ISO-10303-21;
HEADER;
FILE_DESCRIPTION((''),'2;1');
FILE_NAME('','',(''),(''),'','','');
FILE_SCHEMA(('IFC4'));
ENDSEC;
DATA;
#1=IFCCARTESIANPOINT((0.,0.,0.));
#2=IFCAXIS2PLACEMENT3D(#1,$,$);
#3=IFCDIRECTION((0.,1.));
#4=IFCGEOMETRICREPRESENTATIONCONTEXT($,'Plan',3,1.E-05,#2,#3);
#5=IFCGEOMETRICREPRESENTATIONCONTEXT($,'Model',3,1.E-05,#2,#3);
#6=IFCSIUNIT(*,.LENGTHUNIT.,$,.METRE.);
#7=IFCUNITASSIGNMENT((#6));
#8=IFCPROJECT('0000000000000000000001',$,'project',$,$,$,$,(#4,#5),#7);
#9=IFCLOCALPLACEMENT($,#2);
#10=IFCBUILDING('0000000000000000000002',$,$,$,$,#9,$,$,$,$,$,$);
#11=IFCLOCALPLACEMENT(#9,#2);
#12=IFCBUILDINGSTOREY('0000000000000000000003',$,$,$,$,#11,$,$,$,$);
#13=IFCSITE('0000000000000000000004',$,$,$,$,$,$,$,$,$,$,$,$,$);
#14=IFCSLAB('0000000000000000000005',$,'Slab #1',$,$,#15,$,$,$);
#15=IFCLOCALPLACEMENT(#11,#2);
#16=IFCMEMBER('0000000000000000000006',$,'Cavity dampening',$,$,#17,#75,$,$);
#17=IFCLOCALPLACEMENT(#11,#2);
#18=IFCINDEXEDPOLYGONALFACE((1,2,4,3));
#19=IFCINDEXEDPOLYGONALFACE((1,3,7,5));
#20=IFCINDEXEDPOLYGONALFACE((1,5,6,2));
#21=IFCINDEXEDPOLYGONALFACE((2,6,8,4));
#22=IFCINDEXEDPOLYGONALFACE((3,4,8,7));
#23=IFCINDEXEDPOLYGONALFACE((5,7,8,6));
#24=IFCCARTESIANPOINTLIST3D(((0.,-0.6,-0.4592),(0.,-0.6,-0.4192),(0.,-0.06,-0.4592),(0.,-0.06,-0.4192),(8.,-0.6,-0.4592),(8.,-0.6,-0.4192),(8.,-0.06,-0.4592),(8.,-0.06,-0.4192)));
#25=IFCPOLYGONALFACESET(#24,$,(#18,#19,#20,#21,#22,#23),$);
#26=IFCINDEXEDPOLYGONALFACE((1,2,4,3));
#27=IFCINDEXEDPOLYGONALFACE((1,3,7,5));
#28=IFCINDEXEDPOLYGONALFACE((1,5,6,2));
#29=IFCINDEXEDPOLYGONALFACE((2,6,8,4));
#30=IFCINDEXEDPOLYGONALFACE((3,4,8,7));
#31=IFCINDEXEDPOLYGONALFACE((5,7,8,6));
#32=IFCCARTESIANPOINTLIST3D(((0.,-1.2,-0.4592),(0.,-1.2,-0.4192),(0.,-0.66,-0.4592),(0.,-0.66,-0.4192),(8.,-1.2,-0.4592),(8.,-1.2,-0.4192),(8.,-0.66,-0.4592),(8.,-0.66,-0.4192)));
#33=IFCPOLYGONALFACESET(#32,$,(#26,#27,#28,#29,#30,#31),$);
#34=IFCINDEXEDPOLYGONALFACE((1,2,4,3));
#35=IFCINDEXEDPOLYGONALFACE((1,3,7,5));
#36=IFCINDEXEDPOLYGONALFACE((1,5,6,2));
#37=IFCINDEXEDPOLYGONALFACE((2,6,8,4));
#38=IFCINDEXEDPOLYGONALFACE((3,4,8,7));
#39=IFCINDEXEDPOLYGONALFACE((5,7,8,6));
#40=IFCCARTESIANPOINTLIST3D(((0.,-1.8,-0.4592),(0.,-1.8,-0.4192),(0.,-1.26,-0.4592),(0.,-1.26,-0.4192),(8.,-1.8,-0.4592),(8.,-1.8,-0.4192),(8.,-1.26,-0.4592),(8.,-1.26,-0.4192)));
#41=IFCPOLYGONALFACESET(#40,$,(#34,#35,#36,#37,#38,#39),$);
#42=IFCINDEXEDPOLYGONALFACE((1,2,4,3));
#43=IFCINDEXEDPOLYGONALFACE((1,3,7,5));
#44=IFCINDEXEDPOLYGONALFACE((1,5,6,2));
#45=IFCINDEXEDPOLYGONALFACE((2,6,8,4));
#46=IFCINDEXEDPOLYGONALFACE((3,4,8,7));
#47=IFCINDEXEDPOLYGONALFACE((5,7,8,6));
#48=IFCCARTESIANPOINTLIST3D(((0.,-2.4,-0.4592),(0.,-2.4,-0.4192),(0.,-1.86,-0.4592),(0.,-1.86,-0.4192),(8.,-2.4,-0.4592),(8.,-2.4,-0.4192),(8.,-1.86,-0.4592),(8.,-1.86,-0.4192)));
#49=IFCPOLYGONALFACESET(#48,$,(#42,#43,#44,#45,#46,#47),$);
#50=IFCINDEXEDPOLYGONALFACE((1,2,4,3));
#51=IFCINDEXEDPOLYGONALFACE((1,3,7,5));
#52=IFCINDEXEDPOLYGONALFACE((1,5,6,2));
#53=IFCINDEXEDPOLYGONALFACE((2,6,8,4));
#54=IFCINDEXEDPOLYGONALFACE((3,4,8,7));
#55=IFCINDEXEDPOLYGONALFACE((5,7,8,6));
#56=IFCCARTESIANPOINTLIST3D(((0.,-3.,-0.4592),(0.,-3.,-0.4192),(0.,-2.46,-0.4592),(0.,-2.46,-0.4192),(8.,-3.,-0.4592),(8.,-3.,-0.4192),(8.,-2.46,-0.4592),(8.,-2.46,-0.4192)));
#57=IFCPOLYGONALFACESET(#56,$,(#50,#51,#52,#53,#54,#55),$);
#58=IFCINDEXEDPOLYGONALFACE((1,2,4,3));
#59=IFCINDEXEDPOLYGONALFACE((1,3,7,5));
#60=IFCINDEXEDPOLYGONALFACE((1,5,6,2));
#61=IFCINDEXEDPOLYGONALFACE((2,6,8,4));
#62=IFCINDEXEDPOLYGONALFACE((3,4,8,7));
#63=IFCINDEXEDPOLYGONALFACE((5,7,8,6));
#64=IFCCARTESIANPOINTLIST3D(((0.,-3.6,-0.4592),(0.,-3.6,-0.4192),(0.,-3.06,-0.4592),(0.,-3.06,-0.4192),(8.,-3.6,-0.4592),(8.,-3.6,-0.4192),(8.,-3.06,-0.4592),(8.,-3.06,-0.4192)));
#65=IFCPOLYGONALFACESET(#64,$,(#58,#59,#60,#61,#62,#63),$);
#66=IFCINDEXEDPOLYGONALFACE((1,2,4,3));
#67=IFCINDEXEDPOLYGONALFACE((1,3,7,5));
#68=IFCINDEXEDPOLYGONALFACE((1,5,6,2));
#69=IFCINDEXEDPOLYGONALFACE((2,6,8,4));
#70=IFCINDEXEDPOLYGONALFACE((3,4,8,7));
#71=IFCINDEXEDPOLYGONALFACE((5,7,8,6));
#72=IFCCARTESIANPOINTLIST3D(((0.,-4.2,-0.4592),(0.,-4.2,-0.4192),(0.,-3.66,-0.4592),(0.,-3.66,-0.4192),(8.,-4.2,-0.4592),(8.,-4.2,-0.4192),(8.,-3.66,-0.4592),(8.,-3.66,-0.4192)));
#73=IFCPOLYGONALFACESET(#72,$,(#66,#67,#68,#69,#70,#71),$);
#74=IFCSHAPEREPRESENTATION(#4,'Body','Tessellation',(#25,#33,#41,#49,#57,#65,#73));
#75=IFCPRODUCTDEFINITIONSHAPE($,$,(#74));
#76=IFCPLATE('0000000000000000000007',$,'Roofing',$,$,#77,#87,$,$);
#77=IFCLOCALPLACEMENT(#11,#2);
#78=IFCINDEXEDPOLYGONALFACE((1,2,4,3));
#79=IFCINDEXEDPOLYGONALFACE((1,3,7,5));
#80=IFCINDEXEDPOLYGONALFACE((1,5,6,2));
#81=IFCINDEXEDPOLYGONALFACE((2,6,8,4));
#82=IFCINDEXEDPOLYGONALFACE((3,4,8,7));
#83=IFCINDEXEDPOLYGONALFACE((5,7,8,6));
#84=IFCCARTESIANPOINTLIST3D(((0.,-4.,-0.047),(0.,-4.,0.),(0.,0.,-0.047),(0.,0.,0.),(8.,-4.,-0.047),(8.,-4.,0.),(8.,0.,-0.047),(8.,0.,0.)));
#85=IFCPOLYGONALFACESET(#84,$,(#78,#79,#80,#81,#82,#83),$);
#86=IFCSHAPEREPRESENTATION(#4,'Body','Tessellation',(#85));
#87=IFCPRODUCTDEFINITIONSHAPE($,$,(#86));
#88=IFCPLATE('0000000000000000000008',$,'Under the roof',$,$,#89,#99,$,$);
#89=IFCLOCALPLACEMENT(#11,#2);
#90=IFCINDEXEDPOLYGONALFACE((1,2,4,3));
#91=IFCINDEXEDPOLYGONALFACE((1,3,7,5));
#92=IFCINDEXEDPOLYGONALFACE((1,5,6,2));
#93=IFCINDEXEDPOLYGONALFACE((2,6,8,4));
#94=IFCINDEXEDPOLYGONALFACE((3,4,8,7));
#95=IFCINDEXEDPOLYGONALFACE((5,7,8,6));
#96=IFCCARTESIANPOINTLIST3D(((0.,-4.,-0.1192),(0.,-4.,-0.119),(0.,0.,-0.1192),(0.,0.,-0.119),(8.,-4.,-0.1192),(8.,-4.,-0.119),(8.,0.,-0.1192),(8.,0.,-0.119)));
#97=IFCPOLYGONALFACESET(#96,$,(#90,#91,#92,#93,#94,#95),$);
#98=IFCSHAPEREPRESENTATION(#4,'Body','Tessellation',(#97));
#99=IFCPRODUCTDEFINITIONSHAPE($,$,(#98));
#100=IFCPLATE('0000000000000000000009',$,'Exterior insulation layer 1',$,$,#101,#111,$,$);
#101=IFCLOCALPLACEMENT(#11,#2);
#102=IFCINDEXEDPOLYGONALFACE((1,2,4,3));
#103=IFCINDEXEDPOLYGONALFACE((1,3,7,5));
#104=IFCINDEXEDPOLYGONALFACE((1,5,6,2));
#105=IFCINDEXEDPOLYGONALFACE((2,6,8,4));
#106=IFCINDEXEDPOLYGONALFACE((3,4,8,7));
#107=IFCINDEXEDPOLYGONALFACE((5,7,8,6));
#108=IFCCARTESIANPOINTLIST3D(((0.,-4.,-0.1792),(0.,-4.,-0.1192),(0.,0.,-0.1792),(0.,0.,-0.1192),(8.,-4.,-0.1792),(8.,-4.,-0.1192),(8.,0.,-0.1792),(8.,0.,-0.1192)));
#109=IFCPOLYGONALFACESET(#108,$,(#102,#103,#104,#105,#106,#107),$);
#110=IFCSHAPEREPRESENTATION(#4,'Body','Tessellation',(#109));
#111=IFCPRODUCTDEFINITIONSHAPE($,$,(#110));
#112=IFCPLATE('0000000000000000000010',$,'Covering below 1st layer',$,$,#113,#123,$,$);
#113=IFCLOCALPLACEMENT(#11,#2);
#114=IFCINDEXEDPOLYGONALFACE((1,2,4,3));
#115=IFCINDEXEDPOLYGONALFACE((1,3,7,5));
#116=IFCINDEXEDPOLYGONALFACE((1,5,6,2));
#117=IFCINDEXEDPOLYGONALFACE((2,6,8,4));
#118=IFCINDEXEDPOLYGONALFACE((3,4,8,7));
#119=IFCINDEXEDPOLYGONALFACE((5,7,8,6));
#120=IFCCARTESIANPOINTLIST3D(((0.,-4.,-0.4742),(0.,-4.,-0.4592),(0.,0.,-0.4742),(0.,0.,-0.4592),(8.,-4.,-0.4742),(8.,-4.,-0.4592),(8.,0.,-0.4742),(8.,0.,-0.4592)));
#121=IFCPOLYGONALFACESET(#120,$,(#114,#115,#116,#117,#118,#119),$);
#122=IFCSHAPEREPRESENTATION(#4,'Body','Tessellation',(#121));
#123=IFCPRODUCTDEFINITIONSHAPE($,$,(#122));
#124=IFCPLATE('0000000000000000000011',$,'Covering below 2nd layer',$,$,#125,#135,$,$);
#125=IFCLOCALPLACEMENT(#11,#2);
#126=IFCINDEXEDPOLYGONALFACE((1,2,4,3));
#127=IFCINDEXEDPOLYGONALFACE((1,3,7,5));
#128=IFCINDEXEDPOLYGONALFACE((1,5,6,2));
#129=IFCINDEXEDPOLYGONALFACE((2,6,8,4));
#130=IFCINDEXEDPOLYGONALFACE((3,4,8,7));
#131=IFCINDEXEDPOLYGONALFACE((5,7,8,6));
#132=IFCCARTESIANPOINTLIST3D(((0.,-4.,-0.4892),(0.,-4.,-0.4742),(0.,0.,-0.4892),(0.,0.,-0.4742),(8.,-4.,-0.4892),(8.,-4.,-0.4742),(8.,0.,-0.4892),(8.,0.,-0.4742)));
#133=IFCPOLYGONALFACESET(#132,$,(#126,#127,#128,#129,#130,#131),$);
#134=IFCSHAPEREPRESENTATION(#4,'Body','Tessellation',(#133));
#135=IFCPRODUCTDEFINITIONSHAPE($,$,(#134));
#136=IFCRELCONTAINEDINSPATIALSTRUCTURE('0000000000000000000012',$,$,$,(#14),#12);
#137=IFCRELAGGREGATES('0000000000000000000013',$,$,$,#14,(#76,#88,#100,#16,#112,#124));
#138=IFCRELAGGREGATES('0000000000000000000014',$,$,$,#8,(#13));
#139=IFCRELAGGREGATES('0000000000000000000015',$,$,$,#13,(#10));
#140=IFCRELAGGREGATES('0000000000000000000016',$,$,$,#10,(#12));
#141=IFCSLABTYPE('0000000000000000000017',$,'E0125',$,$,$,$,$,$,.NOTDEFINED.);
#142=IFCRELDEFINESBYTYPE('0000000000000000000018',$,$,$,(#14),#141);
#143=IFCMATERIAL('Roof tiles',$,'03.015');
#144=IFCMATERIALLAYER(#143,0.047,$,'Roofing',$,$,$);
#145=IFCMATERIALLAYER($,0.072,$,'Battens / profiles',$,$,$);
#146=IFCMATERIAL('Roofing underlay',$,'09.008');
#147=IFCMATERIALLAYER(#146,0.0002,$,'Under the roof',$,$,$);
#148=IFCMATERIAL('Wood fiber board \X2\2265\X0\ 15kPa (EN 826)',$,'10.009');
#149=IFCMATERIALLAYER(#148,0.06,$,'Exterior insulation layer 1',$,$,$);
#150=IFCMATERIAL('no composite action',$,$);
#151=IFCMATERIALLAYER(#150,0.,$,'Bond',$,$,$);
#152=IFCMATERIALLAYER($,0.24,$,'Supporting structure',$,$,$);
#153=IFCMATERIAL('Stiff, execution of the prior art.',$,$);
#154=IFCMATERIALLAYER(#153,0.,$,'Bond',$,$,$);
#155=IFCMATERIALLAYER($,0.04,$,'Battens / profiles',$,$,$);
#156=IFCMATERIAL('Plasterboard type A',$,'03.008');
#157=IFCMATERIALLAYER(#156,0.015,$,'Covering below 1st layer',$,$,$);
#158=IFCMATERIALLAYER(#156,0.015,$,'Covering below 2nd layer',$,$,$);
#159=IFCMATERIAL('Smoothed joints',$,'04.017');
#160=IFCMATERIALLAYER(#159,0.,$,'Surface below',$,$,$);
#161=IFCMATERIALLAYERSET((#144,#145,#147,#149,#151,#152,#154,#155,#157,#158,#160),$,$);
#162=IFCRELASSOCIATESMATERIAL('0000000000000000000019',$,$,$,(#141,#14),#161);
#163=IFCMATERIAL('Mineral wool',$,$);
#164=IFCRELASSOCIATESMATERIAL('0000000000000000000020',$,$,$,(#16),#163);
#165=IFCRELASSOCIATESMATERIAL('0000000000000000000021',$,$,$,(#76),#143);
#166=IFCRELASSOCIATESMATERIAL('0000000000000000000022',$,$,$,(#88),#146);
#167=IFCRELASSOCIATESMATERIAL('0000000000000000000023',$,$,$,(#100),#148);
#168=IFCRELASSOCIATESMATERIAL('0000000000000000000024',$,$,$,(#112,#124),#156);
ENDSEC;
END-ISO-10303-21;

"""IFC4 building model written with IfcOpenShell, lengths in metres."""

from ifc_helpers import new_model, si_unit, direction, frame, frame_2d, origin, origin_with_axes, place, context, project, spatial, rectangle, extrude, material, layer, layer_set, type_object, element, aggregate, save


model = new_model("IFC4")

# Units and contexts
plan_context = context("Plan", 3, precision=1e-05, world=origin(), true_north=direction((0.0, 1.0)))
model_context = context("Model", 3, precision=1e-05, world=origin(), true_north=direction((0.0, 1.0)))
ifc_project = project(units=[si_unit("LENGTHUNIT", "METRE")], contexts=[plan_context, model_context])

# Site, building, storey
site = spatial("IfcSite", under=ifc_project)
building_placement = place(None, origin())
building = spatial("IfcBuilding", under=site, at=building_placement)
storey_placement = place(building_placement, origin())
storey = spatial("IfcBuildingStorey", under=building, at=storey_placement)

# Slab, member, plates
ifc_material_1 = material(Name="Roof tiles", Category="03.015")
ifc_layer_1 = layer(ifc_material_1, 0.047, Name="Roofing")
ifc_layer_2 = layer(None, 0.072, Name="Battens / profiles")
ifc_material_2 = material(Name="Roofing underlay", Category="09.008")
ifc_layer_3 = layer(ifc_material_2, 0.0002, Name="Under the roof")
ifc_material_3 = material(Name="Wood fiber board ≥ 15kPa (EN 826)", Category="10.009")
ifc_layer_4 = layer(ifc_material_3, 0.06, Name="Exterior insulation layer 1")
ifc_material_4 = material(Name="no composite action")
ifc_layer_5 = layer(ifc_material_4, 0.0, Name="Bond")
ifc_layer_6 = layer(None, 0.24, Name="Supporting structure")
ifc_material_5 = material(Name="Stiff, execution of the prior art.")
ifc_layer_7 = layer(ifc_material_5, 0.0, Name="Bond")
ifc_layer_8 = layer(None, 0.04, Name="Battens / profiles")
ifc_material_6 = material(Name="Plasterboard type A", Category="03.008")
ifc_layer_9 = layer(ifc_material_6, 0.015, Name="Covering below 1st layer")
ifc_layer_10 = layer(ifc_material_6, 0.015, Name="Covering below 2nd layer")
ifc_material_7 = material(Name="Smoothed joints", Category="04.017")
ifc_layer_11 = layer(ifc_material_7, 0.0, Name="Surface below")
ifc_layer_set = layer_set([ifc_layer_1, ifc_layer_2, ifc_layer_3, ifc_layer_4, ifc_layer_5, ifc_layer_6, ifc_layer_7, ifc_layer_8, ifc_layer_9, ifc_layer_10, ifc_layer_11])
slab_type = type_object("IfcSlabType", Name="E0125", PredefinedType="NOTDEFINED", material=ifc_layer_set)
slab_placement = place(None, frame((0.0, 0.0, 0.0), z_axis=(0.0, 0.0, -1.0), x_axis=(1.0, 0.0, 0.0)))
slab = element("IfcSlab", 1, at=slab_placement, inside=storey, type_object=slab_type, material=ifc_layer_set, Name="Slab #1")
ifc_material_8 = material(Name="Mineral wool")
member_1_placement = place(slab_placement, origin())
member_1 = element("IfcMember", 2, at=member_1_placement, material=ifc_material_8, Name="Cavity dampening", context=plan_context, shape_type="SweptSolid", body=[
    extrude(rectangle(XDim=0.54, YDim=0.04, at=frame_2d((0.27, 0.02), x_axis=(1.0, 0.0))), frame((0.0, 0.06, 0.4192), z_axis=(1.0, 0.0, 0.0), x_axis=(0.0, 1.0, 0.0)), (0.0, 0.0, 1.0), 8.0),
    extrude(rectangle(XDim=0.54, YDim=0.04, at=frame_2d((0.27, 0.02), x_axis=(1.0, 0.0))), frame((0.0, 0.66, 0.4192), z_axis=(1.0, 0.0, 0.0), x_axis=(0.0, 1.0, 0.0)), (0.0, 0.0, 1.0), 8.0),
    extrude(rectangle(XDim=0.54, YDim=0.04, at=frame_2d((0.27, 0.02), x_axis=(1.0, 0.0))), frame((0.0, 1.26, 0.4192), z_axis=(1.0, 0.0, 0.0), x_axis=(0.0, 1.0, 0.0)), (0.0, 0.0, 1.0), 8.0),
    extrude(rectangle(XDim=0.54, YDim=0.04, at=frame_2d((0.27, 0.02), x_axis=(1.0, 0.0))), frame((0.0, 1.86, 0.4192), z_axis=(1.0, 0.0, 0.0), x_axis=(0.0, 1.0, 0.0)), (0.0, 0.0, 1.0), 8.0),
    extrude(rectangle(XDim=0.54, YDim=0.04, at=frame_2d((0.27, 0.02), x_axis=(1.0, 0.0))), frame((0.0, 2.46, 0.4192), z_axis=(1.0, 0.0, 0.0), x_axis=(0.0, 1.0, 0.0)), (0.0, 0.0, 1.0), 8.0),
    extrude(rectangle(XDim=0.54, YDim=0.04, at=frame_2d((0.27, 0.02), x_axis=(1.0, 0.0))), frame((0.0, 3.06, 0.4192), z_axis=(1.0, 0.0, 0.0), x_axis=(0.0, 1.0, 0.0)), (0.0, 0.0, 1.0), 8.0),
    extrude(rectangle(XDim=0.54, YDim=0.04, at=frame_2d((0.27, 0.02), x_axis=(1.0, 0.0))), frame((0.0, 3.66, 0.4192), z_axis=(1.0, 0.0, 0.0), x_axis=(0.0, 1.0, 0.0)), (0.0, 0.0, 1.0), 8.0),
])
plate_1_placement = place(slab_placement, origin())
plate_1 = element("IfcPlate", 3, at=plate_1_placement, material=ifc_material_1, Name="Roofing", context=plan_context, shape_type="SweptSolid", body=[
    extrude(rectangle(XDim=8.0, YDim=4.0, at=frame_2d((4.0, 2.0), x_axis=(1.0, 0.0))), origin_with_axes(), (0.0, 0.0, 1.0), 0.047),
])
plate_2_placement = place(slab_placement, origin())
plate_2 = element("IfcPlate", 4, at=plate_2_placement, material=ifc_material_2, Name="Under the roof", context=plan_context, shape_type="SweptSolid", body=[
    extrude(rectangle(XDim=8.0, YDim=4.0, at=frame_2d((4.0, 2.0), x_axis=(1.0, 0.0))), frame((0.0, 0.0, 0.119), z_axis=(0.0, 0.0, 1.0), x_axis=(1.0, 0.0, 0.0)), (0.0, 0.0, 1.0), 0.0002),
])
plate_3_placement = place(slab_placement, origin())
plate_3 = element("IfcPlate", 5, at=plate_3_placement, material=ifc_material_3, Name="Exterior insulation layer 1", context=plan_context, shape_type="SweptSolid", body=[
    extrude(rectangle(XDim=8.0, YDim=4.0, at=frame_2d((4.0, 2.0), x_axis=(1.0, 0.0))), frame((0.0, 0.0, 0.1192), z_axis=(0.0, 0.0, 1.0), x_axis=(1.0, 0.0, 0.0)), (0.0, 0.0, 1.0), 0.06),
])
plate_4_placement = place(slab_placement, origin())
plate_4 = element("IfcPlate", 6, at=plate_4_placement, material=ifc_material_6, Name="Covering below 1st layer", context=plan_context, shape_type="SweptSolid", body=[
    extrude(rectangle(XDim=8.0, YDim=4.0, at=frame_2d((4.0, 2.0), x_axis=(1.0, 0.0))), frame((0.0, 0.0, 0.4592), z_axis=(0.0, 0.0, 1.0), x_axis=(1.0, 0.0, 0.0)), (0.0, 0.0, 1.0), 0.015),
])
plate_5_placement = place(slab_placement, origin())
plate_5 = element("IfcPlate", 7, at=plate_5_placement, material=ifc_material_6, Name="Covering below 2nd layer", context=plan_context, shape_type="SweptSolid", body=[
    extrude(rectangle(XDim=8.0, YDim=4.0, at=frame_2d((4.0, 2.0), x_axis=(1.0, 0.0))), frame((0.0, 0.0, 0.4742), z_axis=(0.0, 0.0, 1.0), x_axis=(1.0, 0.0, 0.0)), (0.0, 0.0, 1.0), 0.015),
])
aggregate(slab, [plate_1, plate_2, plate_3, member_1, plate_4, plate_5])

save(model, "model.ifc")
